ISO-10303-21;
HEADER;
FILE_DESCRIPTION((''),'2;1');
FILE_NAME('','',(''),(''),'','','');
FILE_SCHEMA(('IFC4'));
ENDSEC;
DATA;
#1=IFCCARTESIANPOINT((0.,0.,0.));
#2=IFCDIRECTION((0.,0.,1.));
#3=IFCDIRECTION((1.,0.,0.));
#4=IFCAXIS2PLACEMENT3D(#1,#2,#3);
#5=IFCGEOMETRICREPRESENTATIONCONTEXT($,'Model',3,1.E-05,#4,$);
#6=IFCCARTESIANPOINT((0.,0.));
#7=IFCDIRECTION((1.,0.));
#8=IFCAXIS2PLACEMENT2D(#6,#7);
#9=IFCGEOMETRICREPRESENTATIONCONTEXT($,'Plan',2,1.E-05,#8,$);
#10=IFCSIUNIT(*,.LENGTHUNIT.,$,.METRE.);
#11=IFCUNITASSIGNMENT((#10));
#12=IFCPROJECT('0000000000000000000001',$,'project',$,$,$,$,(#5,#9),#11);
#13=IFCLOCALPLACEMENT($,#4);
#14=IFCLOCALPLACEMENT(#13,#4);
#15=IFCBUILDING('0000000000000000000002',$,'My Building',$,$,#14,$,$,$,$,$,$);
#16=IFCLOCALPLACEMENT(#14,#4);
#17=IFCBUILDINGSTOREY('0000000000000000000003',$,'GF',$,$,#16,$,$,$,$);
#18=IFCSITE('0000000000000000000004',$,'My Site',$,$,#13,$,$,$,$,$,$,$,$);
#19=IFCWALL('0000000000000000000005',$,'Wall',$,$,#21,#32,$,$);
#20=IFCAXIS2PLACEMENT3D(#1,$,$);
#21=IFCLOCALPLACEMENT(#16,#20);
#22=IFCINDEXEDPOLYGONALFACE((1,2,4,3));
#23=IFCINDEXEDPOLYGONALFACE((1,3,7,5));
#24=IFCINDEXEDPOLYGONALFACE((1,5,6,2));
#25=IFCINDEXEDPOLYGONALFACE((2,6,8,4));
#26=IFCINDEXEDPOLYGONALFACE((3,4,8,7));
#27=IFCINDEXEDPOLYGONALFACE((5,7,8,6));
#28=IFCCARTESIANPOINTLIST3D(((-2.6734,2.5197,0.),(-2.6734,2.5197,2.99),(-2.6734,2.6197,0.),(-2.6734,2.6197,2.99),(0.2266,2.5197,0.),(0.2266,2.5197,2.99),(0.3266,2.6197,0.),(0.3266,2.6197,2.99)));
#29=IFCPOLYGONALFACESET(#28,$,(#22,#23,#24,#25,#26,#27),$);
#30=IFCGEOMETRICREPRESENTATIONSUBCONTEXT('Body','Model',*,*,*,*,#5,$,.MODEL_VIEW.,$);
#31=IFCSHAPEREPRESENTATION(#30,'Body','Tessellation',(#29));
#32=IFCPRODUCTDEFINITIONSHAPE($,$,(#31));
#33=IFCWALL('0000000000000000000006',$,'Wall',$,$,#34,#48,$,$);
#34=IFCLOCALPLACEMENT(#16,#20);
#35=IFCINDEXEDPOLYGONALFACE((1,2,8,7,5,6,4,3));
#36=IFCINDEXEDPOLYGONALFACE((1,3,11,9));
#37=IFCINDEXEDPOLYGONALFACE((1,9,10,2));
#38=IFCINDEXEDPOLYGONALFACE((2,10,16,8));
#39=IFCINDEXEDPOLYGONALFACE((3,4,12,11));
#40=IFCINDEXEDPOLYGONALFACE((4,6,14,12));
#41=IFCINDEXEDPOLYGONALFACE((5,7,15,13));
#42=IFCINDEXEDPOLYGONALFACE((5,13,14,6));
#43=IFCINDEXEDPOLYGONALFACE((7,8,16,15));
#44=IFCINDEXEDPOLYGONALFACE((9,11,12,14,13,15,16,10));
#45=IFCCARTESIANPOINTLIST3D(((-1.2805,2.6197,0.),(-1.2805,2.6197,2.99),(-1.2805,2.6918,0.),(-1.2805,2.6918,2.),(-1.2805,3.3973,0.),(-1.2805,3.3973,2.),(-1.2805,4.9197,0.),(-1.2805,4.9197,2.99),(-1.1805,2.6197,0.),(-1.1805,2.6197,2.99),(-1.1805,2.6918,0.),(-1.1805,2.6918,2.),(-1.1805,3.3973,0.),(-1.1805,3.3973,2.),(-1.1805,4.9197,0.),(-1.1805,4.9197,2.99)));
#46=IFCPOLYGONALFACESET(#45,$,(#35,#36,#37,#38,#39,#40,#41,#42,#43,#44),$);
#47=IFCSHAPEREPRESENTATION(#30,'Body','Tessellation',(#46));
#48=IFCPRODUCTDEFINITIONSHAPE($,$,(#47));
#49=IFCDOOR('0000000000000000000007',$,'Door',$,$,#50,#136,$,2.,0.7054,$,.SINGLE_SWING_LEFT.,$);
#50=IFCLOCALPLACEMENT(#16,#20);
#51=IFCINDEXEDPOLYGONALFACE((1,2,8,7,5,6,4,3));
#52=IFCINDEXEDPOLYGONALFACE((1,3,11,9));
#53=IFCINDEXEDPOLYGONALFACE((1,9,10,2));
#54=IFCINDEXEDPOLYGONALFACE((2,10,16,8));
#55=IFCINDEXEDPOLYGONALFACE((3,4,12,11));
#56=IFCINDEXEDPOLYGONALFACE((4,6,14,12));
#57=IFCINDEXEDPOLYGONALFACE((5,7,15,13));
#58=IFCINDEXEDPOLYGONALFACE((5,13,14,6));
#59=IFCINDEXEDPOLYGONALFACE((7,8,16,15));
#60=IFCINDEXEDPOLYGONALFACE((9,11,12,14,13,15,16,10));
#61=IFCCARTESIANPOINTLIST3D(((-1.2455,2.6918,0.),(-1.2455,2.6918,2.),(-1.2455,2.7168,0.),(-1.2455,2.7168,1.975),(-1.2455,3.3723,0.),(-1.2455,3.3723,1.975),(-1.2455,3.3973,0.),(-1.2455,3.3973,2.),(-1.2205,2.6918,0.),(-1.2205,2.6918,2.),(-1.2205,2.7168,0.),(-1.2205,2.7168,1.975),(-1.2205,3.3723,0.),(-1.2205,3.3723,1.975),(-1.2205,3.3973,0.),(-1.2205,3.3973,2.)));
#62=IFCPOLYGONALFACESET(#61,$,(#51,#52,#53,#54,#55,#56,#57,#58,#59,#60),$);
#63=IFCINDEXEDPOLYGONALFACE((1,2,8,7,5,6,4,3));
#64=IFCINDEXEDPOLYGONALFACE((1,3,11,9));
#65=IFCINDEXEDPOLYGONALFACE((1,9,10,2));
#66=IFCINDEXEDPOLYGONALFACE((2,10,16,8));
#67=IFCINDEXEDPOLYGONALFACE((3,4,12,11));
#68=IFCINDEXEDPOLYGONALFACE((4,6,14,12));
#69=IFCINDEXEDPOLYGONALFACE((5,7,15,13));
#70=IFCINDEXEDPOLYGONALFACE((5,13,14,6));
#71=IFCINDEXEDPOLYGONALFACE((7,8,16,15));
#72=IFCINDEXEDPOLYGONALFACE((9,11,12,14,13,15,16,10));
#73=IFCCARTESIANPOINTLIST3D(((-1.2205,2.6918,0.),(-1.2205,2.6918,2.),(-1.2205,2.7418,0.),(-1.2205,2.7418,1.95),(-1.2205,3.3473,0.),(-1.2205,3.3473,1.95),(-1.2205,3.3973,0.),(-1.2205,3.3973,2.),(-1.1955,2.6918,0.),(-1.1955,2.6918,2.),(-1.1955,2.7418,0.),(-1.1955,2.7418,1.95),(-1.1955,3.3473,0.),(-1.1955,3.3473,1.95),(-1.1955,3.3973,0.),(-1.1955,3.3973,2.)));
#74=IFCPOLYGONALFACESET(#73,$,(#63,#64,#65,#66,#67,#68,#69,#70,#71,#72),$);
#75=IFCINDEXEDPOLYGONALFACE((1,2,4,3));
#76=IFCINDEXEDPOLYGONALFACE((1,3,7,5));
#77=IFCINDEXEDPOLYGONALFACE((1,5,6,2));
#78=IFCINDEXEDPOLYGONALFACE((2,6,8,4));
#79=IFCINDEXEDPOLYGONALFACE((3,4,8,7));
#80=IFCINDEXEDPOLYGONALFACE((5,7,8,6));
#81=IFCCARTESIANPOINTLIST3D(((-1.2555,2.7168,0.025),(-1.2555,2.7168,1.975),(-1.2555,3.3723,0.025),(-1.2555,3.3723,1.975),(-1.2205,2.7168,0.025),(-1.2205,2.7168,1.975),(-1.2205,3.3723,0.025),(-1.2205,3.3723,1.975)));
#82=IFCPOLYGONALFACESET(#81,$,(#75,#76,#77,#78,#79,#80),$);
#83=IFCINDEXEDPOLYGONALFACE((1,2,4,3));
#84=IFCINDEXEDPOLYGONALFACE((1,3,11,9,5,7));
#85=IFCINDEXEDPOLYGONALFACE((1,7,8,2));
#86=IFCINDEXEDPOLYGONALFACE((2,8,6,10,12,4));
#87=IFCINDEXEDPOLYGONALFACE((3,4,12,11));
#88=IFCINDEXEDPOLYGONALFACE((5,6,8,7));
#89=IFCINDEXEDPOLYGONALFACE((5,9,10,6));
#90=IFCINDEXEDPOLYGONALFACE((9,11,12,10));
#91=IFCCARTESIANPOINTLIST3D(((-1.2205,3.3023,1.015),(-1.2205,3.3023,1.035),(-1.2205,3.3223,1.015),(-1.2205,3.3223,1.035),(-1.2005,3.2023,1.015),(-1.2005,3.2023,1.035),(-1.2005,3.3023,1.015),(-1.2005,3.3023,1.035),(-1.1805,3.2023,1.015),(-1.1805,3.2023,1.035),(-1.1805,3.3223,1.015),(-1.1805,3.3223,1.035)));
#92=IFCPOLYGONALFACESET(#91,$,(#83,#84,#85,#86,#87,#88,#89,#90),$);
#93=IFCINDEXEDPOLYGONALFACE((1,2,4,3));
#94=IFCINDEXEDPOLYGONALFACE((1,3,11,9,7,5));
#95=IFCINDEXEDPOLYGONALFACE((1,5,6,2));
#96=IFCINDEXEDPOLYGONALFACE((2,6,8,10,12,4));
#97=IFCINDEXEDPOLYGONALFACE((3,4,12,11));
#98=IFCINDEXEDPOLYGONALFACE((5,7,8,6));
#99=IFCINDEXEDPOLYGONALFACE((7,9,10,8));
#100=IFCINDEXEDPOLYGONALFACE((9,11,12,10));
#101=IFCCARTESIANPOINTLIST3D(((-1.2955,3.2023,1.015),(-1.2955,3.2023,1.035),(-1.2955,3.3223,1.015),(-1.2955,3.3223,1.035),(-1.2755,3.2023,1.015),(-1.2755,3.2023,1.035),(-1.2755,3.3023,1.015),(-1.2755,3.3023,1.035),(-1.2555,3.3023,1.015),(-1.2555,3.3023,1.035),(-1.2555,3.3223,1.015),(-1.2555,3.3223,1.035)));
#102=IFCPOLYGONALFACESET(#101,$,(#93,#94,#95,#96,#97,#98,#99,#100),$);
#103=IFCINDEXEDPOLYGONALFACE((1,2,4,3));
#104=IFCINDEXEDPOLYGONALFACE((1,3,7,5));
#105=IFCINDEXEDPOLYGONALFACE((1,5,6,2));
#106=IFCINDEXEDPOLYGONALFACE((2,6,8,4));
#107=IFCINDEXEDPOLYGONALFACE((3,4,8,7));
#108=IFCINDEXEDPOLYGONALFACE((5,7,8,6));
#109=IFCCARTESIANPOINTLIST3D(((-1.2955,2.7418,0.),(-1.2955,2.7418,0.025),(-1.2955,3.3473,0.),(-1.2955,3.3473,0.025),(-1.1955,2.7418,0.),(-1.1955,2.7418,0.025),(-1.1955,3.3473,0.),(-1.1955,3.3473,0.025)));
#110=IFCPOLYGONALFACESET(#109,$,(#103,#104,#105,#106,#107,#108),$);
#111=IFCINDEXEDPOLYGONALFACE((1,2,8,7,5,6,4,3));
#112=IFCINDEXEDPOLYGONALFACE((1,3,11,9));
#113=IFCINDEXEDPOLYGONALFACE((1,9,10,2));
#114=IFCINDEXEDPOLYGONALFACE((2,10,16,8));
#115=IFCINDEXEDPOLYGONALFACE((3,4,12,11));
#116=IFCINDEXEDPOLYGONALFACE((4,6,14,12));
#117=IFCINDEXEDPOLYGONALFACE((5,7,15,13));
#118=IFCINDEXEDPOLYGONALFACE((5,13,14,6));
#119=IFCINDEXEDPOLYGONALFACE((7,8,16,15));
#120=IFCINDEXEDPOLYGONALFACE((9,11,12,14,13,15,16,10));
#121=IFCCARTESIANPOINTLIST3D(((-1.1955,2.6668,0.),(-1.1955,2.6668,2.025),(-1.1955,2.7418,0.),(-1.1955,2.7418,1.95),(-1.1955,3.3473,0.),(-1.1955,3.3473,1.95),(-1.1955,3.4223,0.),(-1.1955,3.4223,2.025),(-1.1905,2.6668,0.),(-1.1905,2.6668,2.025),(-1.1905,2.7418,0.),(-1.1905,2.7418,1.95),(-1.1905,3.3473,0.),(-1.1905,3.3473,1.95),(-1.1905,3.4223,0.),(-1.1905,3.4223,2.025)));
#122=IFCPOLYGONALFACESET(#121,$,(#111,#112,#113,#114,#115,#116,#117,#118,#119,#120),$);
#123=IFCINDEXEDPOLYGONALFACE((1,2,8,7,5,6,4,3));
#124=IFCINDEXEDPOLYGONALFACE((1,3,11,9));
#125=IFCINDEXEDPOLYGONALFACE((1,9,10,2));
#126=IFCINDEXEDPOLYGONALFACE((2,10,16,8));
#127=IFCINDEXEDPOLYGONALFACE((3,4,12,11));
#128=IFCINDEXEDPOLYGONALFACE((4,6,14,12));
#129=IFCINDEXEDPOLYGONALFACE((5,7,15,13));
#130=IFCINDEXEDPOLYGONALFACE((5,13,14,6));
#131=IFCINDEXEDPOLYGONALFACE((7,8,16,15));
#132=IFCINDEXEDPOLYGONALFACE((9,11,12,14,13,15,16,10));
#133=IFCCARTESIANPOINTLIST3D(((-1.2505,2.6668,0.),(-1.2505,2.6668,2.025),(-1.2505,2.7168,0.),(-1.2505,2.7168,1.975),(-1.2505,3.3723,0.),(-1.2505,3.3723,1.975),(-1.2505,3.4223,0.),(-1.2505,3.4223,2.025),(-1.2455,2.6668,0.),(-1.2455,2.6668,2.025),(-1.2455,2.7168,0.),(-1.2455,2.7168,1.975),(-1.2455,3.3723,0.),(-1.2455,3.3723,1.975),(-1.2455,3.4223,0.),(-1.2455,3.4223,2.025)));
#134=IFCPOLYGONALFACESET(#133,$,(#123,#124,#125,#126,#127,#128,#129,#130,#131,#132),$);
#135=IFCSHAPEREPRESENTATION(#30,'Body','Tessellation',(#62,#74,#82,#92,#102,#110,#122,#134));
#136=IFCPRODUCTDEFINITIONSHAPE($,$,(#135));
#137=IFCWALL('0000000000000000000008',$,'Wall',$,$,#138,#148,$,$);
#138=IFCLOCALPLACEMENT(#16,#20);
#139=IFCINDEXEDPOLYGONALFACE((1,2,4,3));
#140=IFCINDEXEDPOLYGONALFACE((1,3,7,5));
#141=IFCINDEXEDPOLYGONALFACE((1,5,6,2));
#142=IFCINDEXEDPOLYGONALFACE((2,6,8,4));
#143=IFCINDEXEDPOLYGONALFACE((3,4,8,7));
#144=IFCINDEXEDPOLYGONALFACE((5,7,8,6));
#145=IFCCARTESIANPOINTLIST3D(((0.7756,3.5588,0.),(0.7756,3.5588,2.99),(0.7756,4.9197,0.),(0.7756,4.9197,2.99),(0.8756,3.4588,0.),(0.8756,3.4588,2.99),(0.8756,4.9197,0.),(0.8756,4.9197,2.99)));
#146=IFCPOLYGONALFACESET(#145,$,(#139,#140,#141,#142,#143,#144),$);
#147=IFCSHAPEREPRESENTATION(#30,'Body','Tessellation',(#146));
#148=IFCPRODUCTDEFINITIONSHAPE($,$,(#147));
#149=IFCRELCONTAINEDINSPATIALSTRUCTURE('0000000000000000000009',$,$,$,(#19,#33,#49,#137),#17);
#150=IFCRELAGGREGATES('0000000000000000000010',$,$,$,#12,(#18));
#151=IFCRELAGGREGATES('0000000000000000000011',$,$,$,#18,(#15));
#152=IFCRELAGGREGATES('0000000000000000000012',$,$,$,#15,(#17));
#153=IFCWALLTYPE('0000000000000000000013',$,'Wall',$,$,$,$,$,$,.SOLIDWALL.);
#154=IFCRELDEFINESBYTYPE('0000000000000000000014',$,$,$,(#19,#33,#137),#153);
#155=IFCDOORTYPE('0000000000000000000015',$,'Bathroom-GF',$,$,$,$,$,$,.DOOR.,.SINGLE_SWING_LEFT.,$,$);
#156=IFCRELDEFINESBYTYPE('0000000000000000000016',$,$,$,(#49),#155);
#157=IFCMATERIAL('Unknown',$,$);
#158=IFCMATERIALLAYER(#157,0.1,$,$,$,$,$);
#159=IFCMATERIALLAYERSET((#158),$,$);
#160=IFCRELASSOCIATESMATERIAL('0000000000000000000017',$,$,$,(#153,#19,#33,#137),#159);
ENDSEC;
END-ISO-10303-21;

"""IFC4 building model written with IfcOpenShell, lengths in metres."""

from ifc_helpers import new_model, entity, si_unit, frame, origin_with_axes, origin_2d_with_axis, place, context, subcontext, project, spatial, line, indexed_curve, outline, extrude, shape, source, transform, mapped, material, layer, layer_set, layer_usage, type_object, type_shapes, element, fill, save


model = new_model("IFC4")

# Units and contexts
model_context = context("Model", 3, precision=1e-05, world=origin_with_axes())
plan_context = context("Plan", 2, precision=1e-05, world=origin_2d_with_axis())
body_context_1 = subcontext(model_context, "Body", "Model", "MODEL_VIEW")
body_context_2 = subcontext(plan_context, "Body", "Plan", "PLAN_VIEW")
ifc_project = project(units=[si_unit("LENGTHUNIT", "METRE")], contexts=[model_context, plan_context])

# Site, building, storey
site_placement = place(None, origin_with_axes())
site = spatial("IfcSite", under=ifc_project, at=site_placement, Name="My Site")
building_placement = place(site_placement, origin_with_axes())
building = spatial("IfcBuilding", under=site, at=building_placement, Name="My Building")
storey_placement = place(building_placement, origin_with_axes())
storey = spatial("IfcBuildingStorey", under=building, at=storey_placement, Name="GF")

# Shared definitions
ifc_material_1 = material(Name="Unknown")

# Shared definitions
ifc_layer_1 = layer(ifc_material_1, 0.1)
ifc_layer_set_1 = layer_set([ifc_layer_1])
wall_type = type_object("IfcWallType", Name="Wall", PredefinedType="SOLIDWALL", material=ifc_layer_set_1)

# Wall
ifc_layer_usage_1 = layer_usage(ifc_layer_set_1, "AXIS2", "POSITIVE", 0.0)
wall_1_placement = place(storey_placement, frame((0.3266, 2.6197, 0.0), z_axis=(0.0, 0.0, 1.0), x_axis=(-1.0, 0.0, 0.0)))
element("IfcWall", 1, at=wall_1_placement, inside=storey, type_object=wall_type, material=ifc_layer_usage_1, Name="Wall", context=body_context_1, shape_type="SweptSolid", body=[
    extrude(outline(indexed_curve([(0.0, 0.0), (0.1, 0.1), (3.0, 0.1), (3.0, 0.0)], segments=[line(1, 2, 3, 4, 1)])), origin_with_axes(), (0.0, 0.0, 1.0), 2.99),
])

# Wall, opening, door
ifc_layer_usage_2 = layer_usage(ifc_layer_set_1, "AXIS2", "POSITIVE", 0.0)
wall_2_placement = place(storey_placement, frame((-1.1805, 2.6197, 0.0), z_axis=(0.0, 0.0, 1.0), x_axis=(0.0, 1.0, 0.0)))
wall_2 = element("IfcWall", 2, at=wall_2_placement, inside=storey, type_object=wall_type, material=ifc_layer_usage_2, Name="Wall", context=body_context_1, shape_type="SweptSolid", body=[
    extrude(outline(indexed_curve([(0.0, 0.0), (0.0, 0.1), (2.3, 0.1), (2.3, 0.0)], segments=[line(1, 2, 3, 4, 1)])), origin_with_axes(), (0.0, 0.0, 1.0), 2.99),
])
shared_shape_1 = source(origin_with_axes(), body_context_1, "Body", "SweptSolid", [
    extrude(outline(indexed_curve([(0.0, 0.0), (0.7054, 0.0), (0.7054, 2.0), (0.0, 2.0)], segments=[line(1, 2, 3, 4, 1)])), frame((0.0, -0.6, 0.0), z_axis=(0.0, -1.0, 0.0), x_axis=(1.0, 0.0, 0.0)), (0.0, 0.0, -1.0), 1.2),
])
opening_1_placement = place(wall_2_placement, frame((0.0721, 0.015, 0.0), z_axis=(0.0, 0.0, 1.0), x_axis=(1.0, 0.0, 0.0)))
opening_1 = element("IfcOpeningElement", 3, at=opening_1_placement, cuts=wall_2, PredefinedType="OPENING", context=body_context_1, shape_type="MappedRepresentation", body=[
    mapped(shared_shape_1, transform((0.0, 0.0, 0.0), x_axis=(1.0, 0.0, 0.0), y_axis=(0.0, 1.0, 0.0), z_axis=(0.0, 0.0, 1.0), scale=1.0)),
])
door_type_1 = type_object("IfcDoorType", Name="Bathroom-GF", OperationType="SINGLE_SWING_LEFT", PredefinedType="DOOR")
shared_shape_2 = source(origin_with_axes(), body_context_1, "Body", "SweptSolid", [
    extrude(outline(indexed_curve([(0.0, 0.0), (0.0, 2.0), (0.7054, 2.0), (0.7054, 0.0), (0.6804, 0.0), (0.6804, 1.975), (0.025, 1.975), (0.025, 0.0)], segments=[line(1, 2, 3, 4, 5, 6, 7, 8, 1)])), frame((0.0, 0.025, 0.0), z_axis=(0.0, -1.0, 0.0), x_axis=(1.0, 0.0, 0.0)), (0.0, 0.0, -1.0), 0.025),
    extrude(outline(indexed_curve([(0.0, 0.0), (0.0, 2.0), (0.7054, 2.0), (0.7054, 0.0), (0.6554, 0.0), (0.6554, 1.95), (0.05, 1.95), (0.05, 0.0)], segments=[line(1, 2, 3, 4, 5, 6, 7, 8, 1)])), frame((0.0, 0.0, 0.0), z_axis=(0.0, -1.0, 0.0), x_axis=(1.0, 0.0, 0.0)), (0.0, 0.0, -1.0), 0.025),
    extrude(outline(indexed_curve([(0.0, 0.0), (0.6554, 0.0), (0.6554, 0.035), (0.0, 0.035)], segments=[line(1, 2, 3, 4, 1)])), frame((0.025, 0.025, 0.025), z_axis=(0.0, 0.0, 1.0), x_axis=(1.0, 0.0, 0.0)), (0.0, 0.0, 1.0), 1.95),
    extrude(outline(indexed_curve([(0.0, 0.0), (0.0, -0.04), (-0.12, -0.04), (-0.12, -0.02), (-0.02, -0.02), (-0.02, 0.0)], segments=[line(1, 2, 3, 4, 5, 6, 1)])), frame((0.6304, 0.025, 1.015), z_axis=(0.0, 0.0, 1.0), x_axis=(1.0, 0.0, 0.0)), (0.0, 0.0, 1.0), 0.02),
    extrude(outline(indexed_curve([(0.0, 0.0), (0.0, 0.04), (-0.12, 0.04), (-0.12, 0.02), (-0.02, 0.02), (-0.02, 0.0)], segments=[line(1, 2, 3, 4, 5, 6, 1)])), frame((0.6304, 0.06, 1.015), z_axis=(0.0, 0.0, 1.0), x_axis=(1.0, 0.0, 0.0)), (0.0, 0.0, 1.0), 0.02),
    extrude(outline(indexed_curve([(0.0, 0.0), (0.6054, 0.0), (0.6054, 0.1), (0.0, 0.1)], segments=[line(1, 2, 3, 4, 1)])), frame((0.05, 0.0, 0.0), z_axis=(0.0, 0.0, 1.0), x_axis=(1.0, 0.0, 0.0)), (0.0, 0.0, 1.0), 0.025),
    extrude(outline(indexed_curve([(0.0, 0.0), (0.0, 2.025), (0.7554, 2.025), (0.7554, 0.0), (0.6804, 0.0), (0.6804, 1.95), (0.075, 1.95), (0.075, 0.0)], segments=[line(1, 2, 3, 4, 5, 6, 7, 8, 1)])), frame((-0.025, -0.005, 0.0), z_axis=(0.0, -1.0, 0.0), x_axis=(1.0, 0.0, 0.0)), (0.0, 0.0, -1.0), 0.005),
    extrude(outline(indexed_curve([(0.0, 0.0), (0.0, 2.025), (0.7554, 2.025), (0.7554, 0.0), (0.7054, 0.0), (0.7054, 1.975), (0.05, 1.975), (0.05, 0.0)], segments=[line(1, 2, 3, 4, 5, 6, 7, 8, 1)])), frame((-0.025, 0.05, 0.0), z_axis=(0.0, -1.0, 0.0), x_axis=(1.0, 0.0, 0.0)), (0.0, 0.0, -1.0), 0.005),
])
shared_shape_3 = source(origin_with_axes(), body_context_2, "Body", "Curve2D", [
    entity("IfcIndexedPolyCurve", entity("IfcCartesianPointList2D", [[0.0, 0.0], [0.0, 0.05], [0.025, 0.05], [0.025, 0.025], [0.05, 0.025], [0.05, 0.0]]), [entity("IfcLineIndex", [1, 2, 3, 4, 5, 6, 1])]),
    entity("IfcIndexedPolyCurve", entity("IfcCartesianPointList2D", [[0.7054, 0.0], [0.7054, 0.05], [0.6804, 0.05], [0.6804, 0.025], [0.6554, 0.025], [0.6554, 0.0]]), [entity("IfcLineIndex", [1, 2, 3, 4, 5, 6, 1])]),
    entity("IfcTrimmedCurve", entity("IfcEllipse", entity("IfcAxis2Placement2D", entity("IfcCartesianPoint", [0.06, 0.05]), entity("IfcDirection", [1.0, 0.0])), 0.6204, 0.6554), [entity("IfcCartesianPoint", [0.6804, 0.05])], [entity("IfcCartesianPoint", [0.06, 0.7054])], True, "CARTESIAN"),
    entity("IfcIndexedPolyCurve", entity("IfcCartesianPointList2D", [[0.025, 0.05], [0.06, 0.05], [0.06, 0.7054], [0.025, 0.7054]]), [entity("IfcLineIndex", [1, 2, 3, 4, 1])]),
])
type_shapes(door_type_1, [shared_shape_2, shared_shape_3])
door_1_placement = place(opening_1_placement, frame((0.0, 0.0, 0.0), z_axis=(0.0, 0.0, 1.0), x_axis=(1.0, 0.0, 0.0)))
door_1 = element("IfcDoor", 4, at=door_1_placement, inside=storey, type_object=door_type_1, Name="Door", OperationType="SINGLE_SWING_LEFT", OverallHeight=2.0, OverallWidth=0.7054, shapes=[
    shape(body_context_1, "Body", "MappedRepresentation", [mapped(shared_shape_2, transform((0.0, 0.0, 0.0), x_axis=(1.0, 0.0, 0.0), y_axis=(0.0, 1.0, 0.0), z_axis=(0.0, 0.0, 1.0), scale=1.0))]),
    shape(body_context_2, "Body", "MappedRepresentation", [mapped(shared_shape_3, transform((0.0, 0.0, 0.0), x_axis=(1.0, 0.0, 0.0), y_axis=(0.0, 1.0, 0.0), z_axis=(0.0, 0.0, 1.0), scale=1.0))]),
])
fill(opening_1, door_1)

# Wall
ifc_layer_usage_3 = layer_usage(ifc_layer_set_1, "AXIS2", "POSITIVE", 0.0)
wall_3_placement = place(storey_placement, frame((0.7756, 5.0197, 0.0), z_axis=(0.0, 0.0, 1.0), x_axis=(0.0, -1.0, 0.0)))
element("IfcWall", 5, at=wall_3_placement, inside=storey, type_object=wall_type, material=ifc_layer_usage_3, Name="Wall", context=body_context_1, shape_type="SweptSolid", body=[
    extrude(outline(indexed_curve([(0.1, 0.0), (0.1, 0.1), (1.561, 0.1), (1.461, 0.0)], segments=[line(1, 2, 3, 4, 1)])), origin_with_axes(), (0.0, 0.0, 1.0), 2.99),
])

save(model, "model.ifc")
